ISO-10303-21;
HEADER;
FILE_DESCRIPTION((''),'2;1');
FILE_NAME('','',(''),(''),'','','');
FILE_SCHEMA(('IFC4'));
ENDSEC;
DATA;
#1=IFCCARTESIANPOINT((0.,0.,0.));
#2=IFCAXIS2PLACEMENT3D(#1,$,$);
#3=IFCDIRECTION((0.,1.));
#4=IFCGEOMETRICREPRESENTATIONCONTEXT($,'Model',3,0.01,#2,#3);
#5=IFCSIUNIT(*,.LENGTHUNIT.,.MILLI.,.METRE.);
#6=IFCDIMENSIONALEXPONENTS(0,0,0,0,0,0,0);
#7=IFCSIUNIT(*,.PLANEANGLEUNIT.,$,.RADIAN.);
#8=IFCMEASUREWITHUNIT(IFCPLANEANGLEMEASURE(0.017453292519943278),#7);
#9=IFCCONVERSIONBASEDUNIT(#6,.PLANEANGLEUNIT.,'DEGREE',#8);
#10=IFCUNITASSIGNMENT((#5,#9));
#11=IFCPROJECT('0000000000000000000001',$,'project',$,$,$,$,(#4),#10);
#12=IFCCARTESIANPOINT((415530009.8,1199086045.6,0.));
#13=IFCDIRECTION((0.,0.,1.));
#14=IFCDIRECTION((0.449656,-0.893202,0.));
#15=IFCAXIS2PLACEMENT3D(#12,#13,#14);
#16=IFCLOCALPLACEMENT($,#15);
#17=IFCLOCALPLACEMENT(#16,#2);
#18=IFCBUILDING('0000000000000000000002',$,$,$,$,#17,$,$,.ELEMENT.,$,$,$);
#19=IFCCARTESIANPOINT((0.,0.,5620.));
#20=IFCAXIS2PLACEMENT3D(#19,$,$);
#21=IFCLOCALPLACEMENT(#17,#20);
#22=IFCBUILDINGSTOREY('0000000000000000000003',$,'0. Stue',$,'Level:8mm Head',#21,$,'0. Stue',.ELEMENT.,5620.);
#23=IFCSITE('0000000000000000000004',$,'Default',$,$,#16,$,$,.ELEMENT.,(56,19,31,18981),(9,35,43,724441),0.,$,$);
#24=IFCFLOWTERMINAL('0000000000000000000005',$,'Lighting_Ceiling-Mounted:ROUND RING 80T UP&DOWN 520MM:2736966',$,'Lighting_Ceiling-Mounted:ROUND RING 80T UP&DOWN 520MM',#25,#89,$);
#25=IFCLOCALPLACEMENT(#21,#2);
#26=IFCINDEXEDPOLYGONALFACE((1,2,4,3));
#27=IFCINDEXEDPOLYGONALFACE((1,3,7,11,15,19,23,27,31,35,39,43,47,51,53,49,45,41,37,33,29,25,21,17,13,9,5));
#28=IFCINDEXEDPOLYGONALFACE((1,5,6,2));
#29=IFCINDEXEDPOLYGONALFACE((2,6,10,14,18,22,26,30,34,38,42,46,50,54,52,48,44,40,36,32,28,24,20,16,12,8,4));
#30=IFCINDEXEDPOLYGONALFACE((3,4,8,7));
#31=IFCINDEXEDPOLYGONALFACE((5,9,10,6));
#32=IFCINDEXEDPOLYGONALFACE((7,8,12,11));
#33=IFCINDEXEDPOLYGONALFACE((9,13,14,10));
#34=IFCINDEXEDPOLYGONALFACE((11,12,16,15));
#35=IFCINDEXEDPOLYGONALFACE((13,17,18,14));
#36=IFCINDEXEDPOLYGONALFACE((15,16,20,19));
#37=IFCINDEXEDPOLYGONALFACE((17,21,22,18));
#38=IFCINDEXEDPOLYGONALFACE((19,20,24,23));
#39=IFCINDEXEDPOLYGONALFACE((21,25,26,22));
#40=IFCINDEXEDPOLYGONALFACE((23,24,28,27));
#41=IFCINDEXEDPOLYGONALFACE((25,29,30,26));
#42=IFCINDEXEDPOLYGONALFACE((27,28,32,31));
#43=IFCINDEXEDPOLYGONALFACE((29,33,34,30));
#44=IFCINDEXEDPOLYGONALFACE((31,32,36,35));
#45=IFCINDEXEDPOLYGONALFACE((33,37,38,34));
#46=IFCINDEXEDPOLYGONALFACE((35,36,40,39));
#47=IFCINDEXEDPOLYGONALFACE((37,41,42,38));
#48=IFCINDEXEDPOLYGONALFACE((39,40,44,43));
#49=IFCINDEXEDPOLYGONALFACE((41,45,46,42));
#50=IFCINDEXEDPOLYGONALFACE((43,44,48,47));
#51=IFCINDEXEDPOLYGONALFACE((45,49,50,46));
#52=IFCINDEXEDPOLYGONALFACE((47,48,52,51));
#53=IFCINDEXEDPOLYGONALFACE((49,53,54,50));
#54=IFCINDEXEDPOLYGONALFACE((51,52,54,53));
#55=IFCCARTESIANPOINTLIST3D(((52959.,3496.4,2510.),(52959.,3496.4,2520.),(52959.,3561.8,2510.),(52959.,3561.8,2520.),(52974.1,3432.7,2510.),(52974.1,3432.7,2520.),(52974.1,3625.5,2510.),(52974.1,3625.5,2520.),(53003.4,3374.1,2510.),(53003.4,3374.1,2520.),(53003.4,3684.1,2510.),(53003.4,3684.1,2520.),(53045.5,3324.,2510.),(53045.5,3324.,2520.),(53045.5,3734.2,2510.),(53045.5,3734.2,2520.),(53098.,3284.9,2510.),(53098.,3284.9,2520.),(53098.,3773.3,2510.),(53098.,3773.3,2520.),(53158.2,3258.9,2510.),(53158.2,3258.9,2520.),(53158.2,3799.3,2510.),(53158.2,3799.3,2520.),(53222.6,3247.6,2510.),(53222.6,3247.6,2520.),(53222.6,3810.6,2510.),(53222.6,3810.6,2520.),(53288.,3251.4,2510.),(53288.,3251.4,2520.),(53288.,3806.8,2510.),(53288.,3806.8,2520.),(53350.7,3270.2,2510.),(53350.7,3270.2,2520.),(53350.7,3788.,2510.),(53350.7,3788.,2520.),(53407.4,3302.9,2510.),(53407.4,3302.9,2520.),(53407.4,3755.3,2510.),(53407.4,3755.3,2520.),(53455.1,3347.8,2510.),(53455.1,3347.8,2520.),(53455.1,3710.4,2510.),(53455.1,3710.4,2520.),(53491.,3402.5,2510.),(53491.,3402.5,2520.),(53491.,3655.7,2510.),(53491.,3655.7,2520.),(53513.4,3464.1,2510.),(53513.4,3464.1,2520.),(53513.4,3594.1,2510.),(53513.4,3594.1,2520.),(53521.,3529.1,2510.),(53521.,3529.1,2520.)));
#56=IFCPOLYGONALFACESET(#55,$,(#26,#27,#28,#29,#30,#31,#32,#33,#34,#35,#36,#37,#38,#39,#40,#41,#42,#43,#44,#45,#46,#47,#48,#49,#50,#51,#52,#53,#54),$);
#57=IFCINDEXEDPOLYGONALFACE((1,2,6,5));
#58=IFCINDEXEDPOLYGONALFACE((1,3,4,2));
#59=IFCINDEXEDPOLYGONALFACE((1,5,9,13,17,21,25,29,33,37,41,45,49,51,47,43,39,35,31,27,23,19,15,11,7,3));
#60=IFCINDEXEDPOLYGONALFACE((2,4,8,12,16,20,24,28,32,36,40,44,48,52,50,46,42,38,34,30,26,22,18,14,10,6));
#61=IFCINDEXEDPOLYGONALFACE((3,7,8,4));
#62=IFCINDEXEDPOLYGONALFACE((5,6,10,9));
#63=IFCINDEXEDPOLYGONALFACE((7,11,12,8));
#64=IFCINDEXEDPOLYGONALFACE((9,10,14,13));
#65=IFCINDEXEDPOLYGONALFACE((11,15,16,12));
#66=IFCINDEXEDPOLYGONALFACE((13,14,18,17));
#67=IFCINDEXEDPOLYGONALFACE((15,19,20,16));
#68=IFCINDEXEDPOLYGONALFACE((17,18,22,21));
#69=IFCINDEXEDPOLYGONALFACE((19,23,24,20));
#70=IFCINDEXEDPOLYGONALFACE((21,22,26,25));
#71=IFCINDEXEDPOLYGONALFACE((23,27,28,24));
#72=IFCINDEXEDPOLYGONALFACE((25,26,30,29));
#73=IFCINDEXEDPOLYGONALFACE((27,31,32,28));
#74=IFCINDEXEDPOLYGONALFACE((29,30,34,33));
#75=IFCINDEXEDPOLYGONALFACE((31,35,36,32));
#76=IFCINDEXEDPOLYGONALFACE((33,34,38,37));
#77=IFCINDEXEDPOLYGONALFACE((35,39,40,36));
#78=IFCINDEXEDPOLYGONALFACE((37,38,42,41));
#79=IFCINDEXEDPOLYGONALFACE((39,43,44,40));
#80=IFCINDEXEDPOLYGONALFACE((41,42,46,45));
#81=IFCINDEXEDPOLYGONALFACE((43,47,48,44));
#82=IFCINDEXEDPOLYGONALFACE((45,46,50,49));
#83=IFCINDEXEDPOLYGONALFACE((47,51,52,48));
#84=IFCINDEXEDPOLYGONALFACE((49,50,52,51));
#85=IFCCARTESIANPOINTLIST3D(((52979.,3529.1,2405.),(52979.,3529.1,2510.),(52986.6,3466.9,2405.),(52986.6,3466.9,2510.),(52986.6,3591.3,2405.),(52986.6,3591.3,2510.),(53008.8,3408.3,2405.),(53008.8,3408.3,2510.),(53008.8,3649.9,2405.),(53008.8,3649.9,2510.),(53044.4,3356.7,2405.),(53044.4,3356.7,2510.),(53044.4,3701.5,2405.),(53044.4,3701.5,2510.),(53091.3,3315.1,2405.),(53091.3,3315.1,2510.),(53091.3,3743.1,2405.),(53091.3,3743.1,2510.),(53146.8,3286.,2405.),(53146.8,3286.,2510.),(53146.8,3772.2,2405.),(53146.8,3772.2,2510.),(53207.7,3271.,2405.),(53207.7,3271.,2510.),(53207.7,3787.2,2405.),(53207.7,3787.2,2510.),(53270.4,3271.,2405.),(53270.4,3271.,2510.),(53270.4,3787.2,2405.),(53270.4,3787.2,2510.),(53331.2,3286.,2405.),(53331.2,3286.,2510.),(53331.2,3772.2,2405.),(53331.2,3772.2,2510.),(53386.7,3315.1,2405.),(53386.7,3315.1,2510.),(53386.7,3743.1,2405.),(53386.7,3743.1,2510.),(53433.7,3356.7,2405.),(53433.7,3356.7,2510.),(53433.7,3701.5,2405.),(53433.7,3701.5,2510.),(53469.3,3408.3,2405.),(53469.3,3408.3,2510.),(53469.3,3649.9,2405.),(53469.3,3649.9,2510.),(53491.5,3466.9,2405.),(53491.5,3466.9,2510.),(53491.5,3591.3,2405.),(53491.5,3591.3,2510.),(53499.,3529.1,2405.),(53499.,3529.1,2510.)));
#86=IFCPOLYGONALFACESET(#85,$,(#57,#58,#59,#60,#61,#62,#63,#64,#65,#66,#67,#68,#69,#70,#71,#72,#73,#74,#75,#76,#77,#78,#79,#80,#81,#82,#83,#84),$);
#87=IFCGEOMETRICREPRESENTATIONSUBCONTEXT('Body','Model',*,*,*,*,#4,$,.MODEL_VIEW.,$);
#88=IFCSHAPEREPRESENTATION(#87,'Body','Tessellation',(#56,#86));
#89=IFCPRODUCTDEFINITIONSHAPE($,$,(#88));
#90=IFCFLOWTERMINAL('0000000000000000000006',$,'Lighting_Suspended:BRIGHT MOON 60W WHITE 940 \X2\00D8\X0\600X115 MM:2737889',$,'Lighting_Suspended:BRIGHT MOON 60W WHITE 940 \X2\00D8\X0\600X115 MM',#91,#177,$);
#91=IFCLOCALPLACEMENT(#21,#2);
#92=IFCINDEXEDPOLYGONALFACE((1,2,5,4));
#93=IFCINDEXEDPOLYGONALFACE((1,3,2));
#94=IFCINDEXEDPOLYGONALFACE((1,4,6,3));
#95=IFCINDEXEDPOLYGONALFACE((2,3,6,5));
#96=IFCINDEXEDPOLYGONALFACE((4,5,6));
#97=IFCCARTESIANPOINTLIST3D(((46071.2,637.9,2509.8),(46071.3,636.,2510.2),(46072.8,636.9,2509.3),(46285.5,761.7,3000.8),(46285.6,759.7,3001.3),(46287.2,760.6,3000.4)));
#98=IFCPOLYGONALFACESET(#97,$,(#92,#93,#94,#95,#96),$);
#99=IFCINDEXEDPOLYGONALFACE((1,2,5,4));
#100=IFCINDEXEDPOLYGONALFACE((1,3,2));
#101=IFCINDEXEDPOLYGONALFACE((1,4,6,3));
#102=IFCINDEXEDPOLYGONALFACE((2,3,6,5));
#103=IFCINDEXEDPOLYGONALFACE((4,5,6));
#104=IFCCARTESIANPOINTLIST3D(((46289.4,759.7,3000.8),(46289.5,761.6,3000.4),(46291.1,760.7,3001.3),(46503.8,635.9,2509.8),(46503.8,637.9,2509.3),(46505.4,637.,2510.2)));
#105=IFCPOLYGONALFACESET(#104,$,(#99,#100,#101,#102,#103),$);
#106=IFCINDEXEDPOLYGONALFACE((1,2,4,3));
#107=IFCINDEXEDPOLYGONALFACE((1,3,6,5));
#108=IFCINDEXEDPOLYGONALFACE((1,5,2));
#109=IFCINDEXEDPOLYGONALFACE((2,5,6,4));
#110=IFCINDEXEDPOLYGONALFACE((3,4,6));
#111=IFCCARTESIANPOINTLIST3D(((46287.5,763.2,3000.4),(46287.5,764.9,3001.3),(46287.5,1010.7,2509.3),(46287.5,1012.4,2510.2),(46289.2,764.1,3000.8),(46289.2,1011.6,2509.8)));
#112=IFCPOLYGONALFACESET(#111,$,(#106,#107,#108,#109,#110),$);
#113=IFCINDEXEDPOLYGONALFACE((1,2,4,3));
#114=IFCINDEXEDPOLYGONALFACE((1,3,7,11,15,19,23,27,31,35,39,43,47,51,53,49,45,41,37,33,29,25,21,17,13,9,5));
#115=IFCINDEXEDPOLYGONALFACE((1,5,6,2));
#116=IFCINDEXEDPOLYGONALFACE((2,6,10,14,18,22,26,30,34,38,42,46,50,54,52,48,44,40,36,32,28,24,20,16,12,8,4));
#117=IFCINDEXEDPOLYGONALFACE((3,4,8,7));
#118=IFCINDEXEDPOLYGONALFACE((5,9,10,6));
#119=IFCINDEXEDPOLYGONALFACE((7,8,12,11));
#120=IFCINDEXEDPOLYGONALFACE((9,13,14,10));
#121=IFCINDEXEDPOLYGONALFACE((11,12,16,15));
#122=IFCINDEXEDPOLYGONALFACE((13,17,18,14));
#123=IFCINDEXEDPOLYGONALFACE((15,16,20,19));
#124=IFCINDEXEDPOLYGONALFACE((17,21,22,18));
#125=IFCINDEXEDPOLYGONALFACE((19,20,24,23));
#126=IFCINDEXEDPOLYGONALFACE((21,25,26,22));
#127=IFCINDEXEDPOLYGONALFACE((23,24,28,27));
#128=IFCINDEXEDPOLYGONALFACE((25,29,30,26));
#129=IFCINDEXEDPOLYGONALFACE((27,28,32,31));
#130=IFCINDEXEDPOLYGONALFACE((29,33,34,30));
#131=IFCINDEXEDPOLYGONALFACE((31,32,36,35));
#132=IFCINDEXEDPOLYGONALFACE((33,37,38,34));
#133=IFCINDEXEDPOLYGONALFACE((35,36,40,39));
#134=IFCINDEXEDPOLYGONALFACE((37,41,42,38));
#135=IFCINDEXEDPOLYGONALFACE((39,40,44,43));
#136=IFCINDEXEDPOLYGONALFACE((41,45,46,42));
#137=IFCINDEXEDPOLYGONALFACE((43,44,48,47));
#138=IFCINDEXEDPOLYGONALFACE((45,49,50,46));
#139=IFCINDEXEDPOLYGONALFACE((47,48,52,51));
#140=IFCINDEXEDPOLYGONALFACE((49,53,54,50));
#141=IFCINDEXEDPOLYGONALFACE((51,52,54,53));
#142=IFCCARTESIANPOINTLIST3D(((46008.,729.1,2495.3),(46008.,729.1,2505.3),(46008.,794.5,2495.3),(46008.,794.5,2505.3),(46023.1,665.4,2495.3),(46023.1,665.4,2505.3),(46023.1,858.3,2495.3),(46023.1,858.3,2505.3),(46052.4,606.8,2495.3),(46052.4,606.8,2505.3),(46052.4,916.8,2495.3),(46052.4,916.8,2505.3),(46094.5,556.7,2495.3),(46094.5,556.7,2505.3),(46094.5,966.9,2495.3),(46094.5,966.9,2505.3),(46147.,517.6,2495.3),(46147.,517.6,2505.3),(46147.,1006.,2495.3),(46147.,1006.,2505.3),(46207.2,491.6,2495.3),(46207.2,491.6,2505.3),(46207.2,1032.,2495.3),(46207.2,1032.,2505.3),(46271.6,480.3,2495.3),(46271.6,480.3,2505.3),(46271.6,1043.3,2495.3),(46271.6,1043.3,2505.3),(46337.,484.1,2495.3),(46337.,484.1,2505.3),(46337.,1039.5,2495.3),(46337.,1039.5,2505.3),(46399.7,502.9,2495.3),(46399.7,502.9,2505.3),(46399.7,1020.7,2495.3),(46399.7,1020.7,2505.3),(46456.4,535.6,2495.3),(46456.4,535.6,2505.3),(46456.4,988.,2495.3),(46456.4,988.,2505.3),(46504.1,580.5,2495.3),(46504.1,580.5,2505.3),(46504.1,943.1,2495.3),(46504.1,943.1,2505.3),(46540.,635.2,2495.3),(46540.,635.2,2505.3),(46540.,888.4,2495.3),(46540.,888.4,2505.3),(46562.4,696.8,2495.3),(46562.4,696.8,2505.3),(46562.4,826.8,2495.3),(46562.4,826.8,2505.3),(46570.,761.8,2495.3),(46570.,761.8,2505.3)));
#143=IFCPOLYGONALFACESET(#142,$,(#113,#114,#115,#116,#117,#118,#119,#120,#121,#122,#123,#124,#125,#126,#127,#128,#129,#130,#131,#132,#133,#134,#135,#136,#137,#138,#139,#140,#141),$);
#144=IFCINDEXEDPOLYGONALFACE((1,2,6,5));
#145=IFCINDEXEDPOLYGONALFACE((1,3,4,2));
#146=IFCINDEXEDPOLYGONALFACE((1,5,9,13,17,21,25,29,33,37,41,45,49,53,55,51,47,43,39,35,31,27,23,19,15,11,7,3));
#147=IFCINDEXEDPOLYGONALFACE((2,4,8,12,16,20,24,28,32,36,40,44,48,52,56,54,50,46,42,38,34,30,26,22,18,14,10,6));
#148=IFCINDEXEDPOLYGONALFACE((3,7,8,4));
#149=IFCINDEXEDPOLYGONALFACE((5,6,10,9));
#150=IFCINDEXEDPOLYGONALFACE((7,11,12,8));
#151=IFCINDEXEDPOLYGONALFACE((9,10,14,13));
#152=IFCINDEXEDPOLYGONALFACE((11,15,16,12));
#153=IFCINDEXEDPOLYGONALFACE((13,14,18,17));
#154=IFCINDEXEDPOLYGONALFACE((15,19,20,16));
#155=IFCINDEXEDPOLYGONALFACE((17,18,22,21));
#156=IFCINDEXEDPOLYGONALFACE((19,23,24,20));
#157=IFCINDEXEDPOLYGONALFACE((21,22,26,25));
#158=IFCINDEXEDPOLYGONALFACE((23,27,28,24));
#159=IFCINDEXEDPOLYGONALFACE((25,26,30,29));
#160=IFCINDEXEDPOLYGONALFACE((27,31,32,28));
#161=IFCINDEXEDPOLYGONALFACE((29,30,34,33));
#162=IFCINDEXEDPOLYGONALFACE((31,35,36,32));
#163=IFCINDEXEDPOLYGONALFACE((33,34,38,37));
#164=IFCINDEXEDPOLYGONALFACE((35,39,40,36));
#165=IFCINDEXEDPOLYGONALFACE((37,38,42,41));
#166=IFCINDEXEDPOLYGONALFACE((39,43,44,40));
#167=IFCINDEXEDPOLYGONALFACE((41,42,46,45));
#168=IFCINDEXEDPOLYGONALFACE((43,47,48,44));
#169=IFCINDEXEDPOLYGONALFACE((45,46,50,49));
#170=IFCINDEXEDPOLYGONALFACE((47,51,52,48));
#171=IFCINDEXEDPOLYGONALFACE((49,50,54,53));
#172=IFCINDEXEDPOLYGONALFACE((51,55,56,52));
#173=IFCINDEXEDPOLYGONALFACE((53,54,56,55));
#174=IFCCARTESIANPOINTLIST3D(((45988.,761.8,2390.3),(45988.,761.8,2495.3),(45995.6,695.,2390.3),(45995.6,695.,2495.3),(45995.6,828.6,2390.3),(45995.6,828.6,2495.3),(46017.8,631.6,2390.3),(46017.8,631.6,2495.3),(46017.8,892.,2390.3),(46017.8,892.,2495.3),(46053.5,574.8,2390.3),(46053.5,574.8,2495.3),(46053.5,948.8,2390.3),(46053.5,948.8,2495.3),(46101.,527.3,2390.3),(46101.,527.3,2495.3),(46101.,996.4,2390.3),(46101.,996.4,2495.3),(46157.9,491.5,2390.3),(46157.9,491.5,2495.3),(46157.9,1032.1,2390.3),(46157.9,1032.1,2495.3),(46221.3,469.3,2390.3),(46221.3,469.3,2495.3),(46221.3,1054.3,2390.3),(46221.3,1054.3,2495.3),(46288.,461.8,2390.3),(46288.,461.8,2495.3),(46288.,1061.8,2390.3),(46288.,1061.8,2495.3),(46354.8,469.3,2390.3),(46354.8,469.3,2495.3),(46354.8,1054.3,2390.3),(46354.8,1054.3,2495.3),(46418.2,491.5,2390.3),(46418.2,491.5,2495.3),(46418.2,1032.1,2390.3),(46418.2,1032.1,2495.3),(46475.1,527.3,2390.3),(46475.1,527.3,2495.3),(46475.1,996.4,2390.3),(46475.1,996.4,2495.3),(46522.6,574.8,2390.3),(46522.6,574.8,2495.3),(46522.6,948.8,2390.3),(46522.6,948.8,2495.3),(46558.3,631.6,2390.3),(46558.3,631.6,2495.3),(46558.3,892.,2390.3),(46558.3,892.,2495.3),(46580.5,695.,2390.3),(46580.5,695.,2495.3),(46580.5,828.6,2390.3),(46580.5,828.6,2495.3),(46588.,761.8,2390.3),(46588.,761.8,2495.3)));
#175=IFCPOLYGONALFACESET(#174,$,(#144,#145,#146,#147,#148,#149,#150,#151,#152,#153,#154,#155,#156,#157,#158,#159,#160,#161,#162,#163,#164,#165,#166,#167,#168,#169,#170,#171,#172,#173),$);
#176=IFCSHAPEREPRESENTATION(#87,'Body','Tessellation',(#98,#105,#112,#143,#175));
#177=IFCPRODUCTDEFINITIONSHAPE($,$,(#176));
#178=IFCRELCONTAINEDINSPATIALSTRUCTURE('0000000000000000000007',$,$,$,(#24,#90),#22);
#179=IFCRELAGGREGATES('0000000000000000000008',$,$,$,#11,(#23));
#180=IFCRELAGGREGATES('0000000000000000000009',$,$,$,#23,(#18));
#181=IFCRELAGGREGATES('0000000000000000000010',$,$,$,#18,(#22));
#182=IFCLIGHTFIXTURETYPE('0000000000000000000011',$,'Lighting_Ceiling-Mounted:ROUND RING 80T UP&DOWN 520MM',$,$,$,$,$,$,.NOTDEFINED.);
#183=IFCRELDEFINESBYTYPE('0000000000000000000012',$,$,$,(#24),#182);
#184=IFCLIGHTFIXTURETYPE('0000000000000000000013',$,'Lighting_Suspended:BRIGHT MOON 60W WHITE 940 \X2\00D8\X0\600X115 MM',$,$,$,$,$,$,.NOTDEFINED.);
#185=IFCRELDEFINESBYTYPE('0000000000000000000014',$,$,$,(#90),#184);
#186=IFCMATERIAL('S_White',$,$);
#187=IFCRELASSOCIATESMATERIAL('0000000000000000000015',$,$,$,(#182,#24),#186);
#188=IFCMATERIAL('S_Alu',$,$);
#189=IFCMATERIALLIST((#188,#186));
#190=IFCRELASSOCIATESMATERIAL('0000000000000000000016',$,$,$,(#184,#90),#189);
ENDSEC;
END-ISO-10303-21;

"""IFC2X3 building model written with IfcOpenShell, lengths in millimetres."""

from ifc_helpers import new_model, entity, si_unit, converted_unit, direction, frame, frame_2d, origin, place, context, subcontext, project, spatial, polyline, circle, outline, extrude, source, transform, mapped, material, material_list, type_object, type_shapes, element, save


model = new_model("IFC2X3")

# Units and contexts
model_context = context("Model", 3, precision=0.01, world=origin(), true_north=direction((0.0, 1.0)))
body_context = subcontext(model_context, "Body", "Model", "MODEL_VIEW")
ifc_project = project(units=[si_unit("LENGTHUNIT", "METRE", prefix="MILLI"), converted_unit("PLANEANGLEUNIT", "DEGREE", entity("IfcPlaneAngleMeasure", 0.017453292519943278), si_unit("PLANEANGLEUNIT", "RADIAN"), dimensions=[0, 0, 0, 0, 0, 0, 0])], contexts=[model_context])

# Site, building, storey
site_placement = place(None, frame((415530009.8, 1199086045.6, 0.0), z_axis=(0.0, 0.0, 1.0), x_axis=(0.449656, -0.893202, 0.0)))
site = spatial("IfcSite", under=ifc_project, at=site_placement, Name="Default", CompositionType="ELEMENT", RefLatitude=(56, 19, 31, 18981), RefLongitude=(9, 35, 43, 724441), RefElevation=0.0)
building_placement = place(site_placement, origin())
building = spatial("IfcBuilding", under=site, at=building_placement, CompositionType="ELEMENT")
storey_placement = place(building_placement, frame((0.0, 0.0, 5620.0)))
storey = spatial("IfcBuildingStorey", under=building, at=storey_placement, Name="0. Stue", ObjectType="Level:8mm Head", LongName="0. Stue", CompositionType="ELEMENT", Elevation=5620.0)

# Flow terminals
ifc_material_1 = material(Name="S_White")
light_fixture_type_1 = type_object("IfcLightFixtureType", Name="Lighting_Ceiling-Mounted:ROUND RING 80T UP&DOWN 520MM", PredefinedType="NOTDEFINED", material=ifc_material_1)
shared_shape_1 = source(origin(), body_context, "Body", "SweptSolid", [
    extrude(circle(Radius=282.0, at=frame_2d((0.0, 0.0), x_axis=(1.0, 0.0))), frame((0.0, 0.0, -10.0)), (0.0, 0.0, 1.0), 10.0),
    extrude(circle(Radius=260.0, at=frame_2d((0.0, 0.0), x_axis=(1.0, 0.0))), frame((0.0, 0.0, -115.0)), (0.0, 0.0, 1.0), 105.0),
])
type_shapes(light_fixture_type_1, [shared_shape_1])
flow_terminal_placement = place(storey_placement, frame((53239.0, 3529.1, 2520.0)))
element("IfcFlowTerminal", 1, at=flow_terminal_placement, inside=storey, type_object=light_fixture_type_1, material=ifc_material_1, Name="Lighting_Ceiling-Mounted:ROUND RING 80T UP&DOWN 520MM:2736966", ObjectType="Lighting_Ceiling-Mounted:ROUND RING 80T UP&DOWN 520MM", context=body_context, shape_type="MappedRepresentation", body=[
    mapped(shared_shape_1, transform((0.0, 0.0, 0.0), scale=1.0)),
])
ifc_material_2 = material(Name="S_Alu")
ifc_material_list = material_list([ifc_material_2, ifc_material_1])
light_fixture_type_2 = type_object("IfcLightFixtureType", Name="Lighting_Suspended:BRIGHT MOON 60W WHITE 940 Ø600X115 MM", PredefinedType="NOTDEFINED", material=ifc_material_list)
shared_shape_2 = source(origin(), body_context, "Body", "SweptSolid", [
    extrude(outline(polyline([(-1.0, -0.6), (1.0, -0.6), (0.0, 1.2), (-1.0, -0.6)])), frame((-216.3, -124.9, -495.5), z_axis=(0.389771, 0.225034, 0.892994), x_axis=(-0.81969, 0.526752, 0.225034)), (0.0, 0.0, 1.0), 549.9),
    extrude(outline(polyline([(-1.0, -0.6), (1.0, -0.6), (0.0, 1.2), (-1.0, -0.6)])), frame((216.3, -124.9, -495.5), z_axis=(-0.389771, 0.225034, 0.892994), x_axis=(-0.046335, -0.973248, 0.225034)), (0.0, 0.0, 1.0), 549.9),
    extrude(outline(polyline([(-1.0, -0.6), (1.0, -0.6), (0.0, 1.2), (-1.0, -0.6)])), frame((0.0, 249.7, -495.5), z_axis=(0.0, -0.450069, 0.892994), x_axis=(0.866025, 0.446497, 0.225034)), (0.0, 0.0, 1.0), 549.9),
    extrude(circle(Radius=282.0, at=frame_2d((0.0, 0.0), x_axis=(1.0, 0.0))), frame((0.0, 0.0, -510.0)), (0.0, 0.0, 1.0), 10.0),
    extrude(circle(Radius=300.0, at=frame_2d((0.0, 0.0), x_axis=(1.0, 0.0))), frame((0.0, 0.0, -615.0)), (0.0, 0.0, 1.0), 105.0),
])
type_shapes(light_fixture_type_2, [shared_shape_2])
for number, where, name in (
    (2, (46288.0, 761.8, 3005.3), "Lighting_Suspended:BRIGHT MOON 60W WHITE 940 Ø600X115 MM:2737889"),
):
    element("IfcFlowTerminal", number, at=place(storey_placement, frame(where)), inside=storey, type_object=light_fixture_type_2, material=ifc_material_list, Name=name, ObjectType="Lighting_Suspended:BRIGHT MOON 60W WHITE 940 Ø600X115 MM", context=body_context, shape_type="MappedRepresentation", body=[
        mapped(shared_shape_2, transform((0.0, 0.0, 0.0), scale=1.0)),
    ])

save(model, "model.ifc")
